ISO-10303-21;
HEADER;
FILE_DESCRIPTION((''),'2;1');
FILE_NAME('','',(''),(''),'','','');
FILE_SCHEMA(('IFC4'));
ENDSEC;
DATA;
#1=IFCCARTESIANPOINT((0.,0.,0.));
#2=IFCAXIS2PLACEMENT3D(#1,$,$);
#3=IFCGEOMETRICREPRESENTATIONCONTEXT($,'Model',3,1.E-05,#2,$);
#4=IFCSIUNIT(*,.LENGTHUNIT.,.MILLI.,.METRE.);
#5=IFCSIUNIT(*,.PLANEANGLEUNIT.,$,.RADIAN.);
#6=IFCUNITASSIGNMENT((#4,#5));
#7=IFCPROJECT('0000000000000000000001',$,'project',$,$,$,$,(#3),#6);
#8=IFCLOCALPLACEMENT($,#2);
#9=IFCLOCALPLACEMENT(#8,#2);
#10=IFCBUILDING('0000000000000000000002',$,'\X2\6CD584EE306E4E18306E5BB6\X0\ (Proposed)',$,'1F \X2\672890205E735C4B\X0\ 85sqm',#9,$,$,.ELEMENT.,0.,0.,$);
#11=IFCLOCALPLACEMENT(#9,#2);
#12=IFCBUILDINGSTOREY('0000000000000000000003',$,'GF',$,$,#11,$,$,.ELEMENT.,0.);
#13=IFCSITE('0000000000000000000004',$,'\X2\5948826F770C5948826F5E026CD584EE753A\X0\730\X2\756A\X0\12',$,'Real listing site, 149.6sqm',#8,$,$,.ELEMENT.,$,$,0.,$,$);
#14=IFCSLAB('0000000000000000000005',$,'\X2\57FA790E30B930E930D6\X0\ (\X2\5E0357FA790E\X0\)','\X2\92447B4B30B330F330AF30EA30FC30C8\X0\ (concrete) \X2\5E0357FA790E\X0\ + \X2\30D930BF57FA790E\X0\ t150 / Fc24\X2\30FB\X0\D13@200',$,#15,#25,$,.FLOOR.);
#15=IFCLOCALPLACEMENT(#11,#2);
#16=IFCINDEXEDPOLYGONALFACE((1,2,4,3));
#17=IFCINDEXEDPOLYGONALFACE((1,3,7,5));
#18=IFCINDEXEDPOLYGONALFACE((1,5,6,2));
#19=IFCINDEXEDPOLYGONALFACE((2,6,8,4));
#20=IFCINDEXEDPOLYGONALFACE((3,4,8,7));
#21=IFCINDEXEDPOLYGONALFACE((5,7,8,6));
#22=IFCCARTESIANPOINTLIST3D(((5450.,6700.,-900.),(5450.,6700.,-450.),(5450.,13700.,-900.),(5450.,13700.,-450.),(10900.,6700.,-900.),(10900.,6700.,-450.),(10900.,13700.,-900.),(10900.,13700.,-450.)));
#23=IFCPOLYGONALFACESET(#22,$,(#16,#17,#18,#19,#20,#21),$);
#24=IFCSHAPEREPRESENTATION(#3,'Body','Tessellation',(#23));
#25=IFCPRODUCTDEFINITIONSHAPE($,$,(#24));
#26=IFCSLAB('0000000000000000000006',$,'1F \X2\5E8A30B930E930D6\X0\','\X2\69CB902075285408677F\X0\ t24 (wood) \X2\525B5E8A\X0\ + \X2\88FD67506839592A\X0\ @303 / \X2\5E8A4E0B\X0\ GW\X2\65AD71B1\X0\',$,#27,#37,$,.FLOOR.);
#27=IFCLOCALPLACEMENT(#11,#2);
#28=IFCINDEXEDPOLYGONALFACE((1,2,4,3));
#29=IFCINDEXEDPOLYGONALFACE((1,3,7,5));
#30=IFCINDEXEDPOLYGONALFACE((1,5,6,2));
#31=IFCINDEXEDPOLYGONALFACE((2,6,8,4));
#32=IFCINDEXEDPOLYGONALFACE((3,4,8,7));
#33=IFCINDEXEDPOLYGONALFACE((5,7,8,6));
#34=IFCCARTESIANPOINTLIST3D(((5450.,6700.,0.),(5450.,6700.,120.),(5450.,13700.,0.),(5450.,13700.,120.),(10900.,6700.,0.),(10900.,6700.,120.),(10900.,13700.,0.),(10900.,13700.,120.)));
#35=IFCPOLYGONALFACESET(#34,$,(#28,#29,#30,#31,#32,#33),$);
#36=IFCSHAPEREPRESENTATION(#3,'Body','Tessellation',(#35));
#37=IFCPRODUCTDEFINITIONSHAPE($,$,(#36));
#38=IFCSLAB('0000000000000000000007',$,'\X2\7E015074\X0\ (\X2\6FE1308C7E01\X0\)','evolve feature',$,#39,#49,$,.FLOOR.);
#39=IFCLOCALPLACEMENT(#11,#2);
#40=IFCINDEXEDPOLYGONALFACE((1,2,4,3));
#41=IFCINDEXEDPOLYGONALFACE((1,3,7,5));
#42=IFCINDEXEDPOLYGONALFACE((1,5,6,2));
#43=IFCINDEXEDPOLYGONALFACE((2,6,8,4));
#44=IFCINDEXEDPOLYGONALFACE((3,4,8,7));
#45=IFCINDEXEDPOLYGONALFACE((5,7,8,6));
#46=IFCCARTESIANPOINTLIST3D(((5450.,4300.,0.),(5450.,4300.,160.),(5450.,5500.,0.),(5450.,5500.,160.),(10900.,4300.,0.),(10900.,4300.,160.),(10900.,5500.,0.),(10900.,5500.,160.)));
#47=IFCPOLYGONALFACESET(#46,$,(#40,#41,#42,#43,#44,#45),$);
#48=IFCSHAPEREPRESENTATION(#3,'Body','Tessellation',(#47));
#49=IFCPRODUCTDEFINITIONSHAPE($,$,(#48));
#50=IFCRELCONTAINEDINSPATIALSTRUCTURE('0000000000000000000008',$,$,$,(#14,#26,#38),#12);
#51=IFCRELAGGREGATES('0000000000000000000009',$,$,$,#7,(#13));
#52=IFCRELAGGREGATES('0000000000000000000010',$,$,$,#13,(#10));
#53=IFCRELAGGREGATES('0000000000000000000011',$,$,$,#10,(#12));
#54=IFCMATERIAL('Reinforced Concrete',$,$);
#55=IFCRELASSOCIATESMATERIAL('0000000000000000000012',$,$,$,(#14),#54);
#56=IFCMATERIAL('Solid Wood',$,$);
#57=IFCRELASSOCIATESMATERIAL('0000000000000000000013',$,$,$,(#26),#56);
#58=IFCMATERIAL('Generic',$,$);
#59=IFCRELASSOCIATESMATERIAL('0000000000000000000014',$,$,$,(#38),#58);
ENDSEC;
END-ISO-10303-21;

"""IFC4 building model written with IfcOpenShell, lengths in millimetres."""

from ifc_helpers import new_model, si_unit, frame, frame_2d, origin, place, context, project, spatial, rectangle, extrude, material, element, save


model = new_model("IFC4")

# Units and contexts
model_context = context("Model", 3, precision=1e-05, world=origin())
ifc_project = project(units=[si_unit("LENGTHUNIT", "METRE", prefix="MILLI"), si_unit("PLANEANGLEUNIT", "RADIAN")], contexts=[model_context])

# Site, building, storey
site_placement = place(None, origin())
site = spatial("IfcSite", under=ifc_project, at=site_placement, Name="奈良県奈良市法蓮町730番12", ObjectType="Real listing site, 149.6sqm", CompositionType="ELEMENT", RefElevation=0.0)
building_placement = place(site_placement, origin())
building = spatial("IfcBuilding", under=site, at=building_placement, Name="法蓮の丘の家 (Proposed)", ObjectType="1F 木造平屋 85sqm", CompositionType="ELEMENT", ElevationOfRefHeight=0.0, ElevationOfTerrain=0.0)
storey_placement = place(building_placement, origin())
storey = spatial("IfcBuildingStorey", under=building, at=storey_placement, Name="GF", CompositionType="ELEMENT", Elevation=0.0)

# Slabs
ifc_material_1 = material(Name="Reinforced Concrete")
slab_1_placement = place(storey_placement, frame((2725.0, 3350.0, -450.0)))
element("IfcSlab", 1, at=slab_1_placement, inside=storey, material=ifc_material_1, Name="基礎スラブ (布基礎)", Description="鉄筋コンクリート (concrete) 布基礎 + ベタ基礎 t150 / Fc24・D13@200", PredefinedType="FLOOR", context=model_context, shape_type="SweptSolid", body=[
    extrude(rectangle(XDim=5450.0, YDim=7000.0, at=frame_2d((2725.0, 3500.0))), frame((2725.0, 3350.0, -450.0)), (0.0, 0.0, 1.0), 450.0),
])
ifc_material_2 = material(Name="Solid Wood")
slab_2_placement = place(storey_placement, frame((2725.0, 3350.0, 0.0)))
element("IfcSlab", 2, at=slab_2_placement, inside=storey, material=ifc_material_2, Name="1F 床スラブ", Description="構造用合板 t24 (wood) 剛床 + 製材根太 @303 / 床下 GW断熱", PredefinedType="FLOOR", context=model_context, shape_type="SweptSolid", body=[
    extrude(rectangle(XDim=5450.0, YDim=7000.0, at=frame_2d((2725.0, 3500.0))), frame((2725.0, 3350.0, 0.0)), (0.0, 0.0, 1.0), 120.0),
])
ifc_material_3 = material(Name="Generic")
slab_3_placement = place(storey_placement, frame((2725.0, 2150.0, 0.0)))
element("IfcSlab", 3, at=slab_3_placement, inside=storey, material=ifc_material_3, Name="縁側 (濡れ縁)", Description="evolve feature", PredefinedType="FLOOR", context=model_context, shape_type="SweptSolid", body=[
    extrude(rectangle(XDim=5450.0, YDim=1200.0, at=frame_2d((2725.0, 600.0))), frame((2725.0, 2150.0, 0.0)), (0.0, 0.0, 1.0), 160.0),
])

save(model, "model.ifc")
